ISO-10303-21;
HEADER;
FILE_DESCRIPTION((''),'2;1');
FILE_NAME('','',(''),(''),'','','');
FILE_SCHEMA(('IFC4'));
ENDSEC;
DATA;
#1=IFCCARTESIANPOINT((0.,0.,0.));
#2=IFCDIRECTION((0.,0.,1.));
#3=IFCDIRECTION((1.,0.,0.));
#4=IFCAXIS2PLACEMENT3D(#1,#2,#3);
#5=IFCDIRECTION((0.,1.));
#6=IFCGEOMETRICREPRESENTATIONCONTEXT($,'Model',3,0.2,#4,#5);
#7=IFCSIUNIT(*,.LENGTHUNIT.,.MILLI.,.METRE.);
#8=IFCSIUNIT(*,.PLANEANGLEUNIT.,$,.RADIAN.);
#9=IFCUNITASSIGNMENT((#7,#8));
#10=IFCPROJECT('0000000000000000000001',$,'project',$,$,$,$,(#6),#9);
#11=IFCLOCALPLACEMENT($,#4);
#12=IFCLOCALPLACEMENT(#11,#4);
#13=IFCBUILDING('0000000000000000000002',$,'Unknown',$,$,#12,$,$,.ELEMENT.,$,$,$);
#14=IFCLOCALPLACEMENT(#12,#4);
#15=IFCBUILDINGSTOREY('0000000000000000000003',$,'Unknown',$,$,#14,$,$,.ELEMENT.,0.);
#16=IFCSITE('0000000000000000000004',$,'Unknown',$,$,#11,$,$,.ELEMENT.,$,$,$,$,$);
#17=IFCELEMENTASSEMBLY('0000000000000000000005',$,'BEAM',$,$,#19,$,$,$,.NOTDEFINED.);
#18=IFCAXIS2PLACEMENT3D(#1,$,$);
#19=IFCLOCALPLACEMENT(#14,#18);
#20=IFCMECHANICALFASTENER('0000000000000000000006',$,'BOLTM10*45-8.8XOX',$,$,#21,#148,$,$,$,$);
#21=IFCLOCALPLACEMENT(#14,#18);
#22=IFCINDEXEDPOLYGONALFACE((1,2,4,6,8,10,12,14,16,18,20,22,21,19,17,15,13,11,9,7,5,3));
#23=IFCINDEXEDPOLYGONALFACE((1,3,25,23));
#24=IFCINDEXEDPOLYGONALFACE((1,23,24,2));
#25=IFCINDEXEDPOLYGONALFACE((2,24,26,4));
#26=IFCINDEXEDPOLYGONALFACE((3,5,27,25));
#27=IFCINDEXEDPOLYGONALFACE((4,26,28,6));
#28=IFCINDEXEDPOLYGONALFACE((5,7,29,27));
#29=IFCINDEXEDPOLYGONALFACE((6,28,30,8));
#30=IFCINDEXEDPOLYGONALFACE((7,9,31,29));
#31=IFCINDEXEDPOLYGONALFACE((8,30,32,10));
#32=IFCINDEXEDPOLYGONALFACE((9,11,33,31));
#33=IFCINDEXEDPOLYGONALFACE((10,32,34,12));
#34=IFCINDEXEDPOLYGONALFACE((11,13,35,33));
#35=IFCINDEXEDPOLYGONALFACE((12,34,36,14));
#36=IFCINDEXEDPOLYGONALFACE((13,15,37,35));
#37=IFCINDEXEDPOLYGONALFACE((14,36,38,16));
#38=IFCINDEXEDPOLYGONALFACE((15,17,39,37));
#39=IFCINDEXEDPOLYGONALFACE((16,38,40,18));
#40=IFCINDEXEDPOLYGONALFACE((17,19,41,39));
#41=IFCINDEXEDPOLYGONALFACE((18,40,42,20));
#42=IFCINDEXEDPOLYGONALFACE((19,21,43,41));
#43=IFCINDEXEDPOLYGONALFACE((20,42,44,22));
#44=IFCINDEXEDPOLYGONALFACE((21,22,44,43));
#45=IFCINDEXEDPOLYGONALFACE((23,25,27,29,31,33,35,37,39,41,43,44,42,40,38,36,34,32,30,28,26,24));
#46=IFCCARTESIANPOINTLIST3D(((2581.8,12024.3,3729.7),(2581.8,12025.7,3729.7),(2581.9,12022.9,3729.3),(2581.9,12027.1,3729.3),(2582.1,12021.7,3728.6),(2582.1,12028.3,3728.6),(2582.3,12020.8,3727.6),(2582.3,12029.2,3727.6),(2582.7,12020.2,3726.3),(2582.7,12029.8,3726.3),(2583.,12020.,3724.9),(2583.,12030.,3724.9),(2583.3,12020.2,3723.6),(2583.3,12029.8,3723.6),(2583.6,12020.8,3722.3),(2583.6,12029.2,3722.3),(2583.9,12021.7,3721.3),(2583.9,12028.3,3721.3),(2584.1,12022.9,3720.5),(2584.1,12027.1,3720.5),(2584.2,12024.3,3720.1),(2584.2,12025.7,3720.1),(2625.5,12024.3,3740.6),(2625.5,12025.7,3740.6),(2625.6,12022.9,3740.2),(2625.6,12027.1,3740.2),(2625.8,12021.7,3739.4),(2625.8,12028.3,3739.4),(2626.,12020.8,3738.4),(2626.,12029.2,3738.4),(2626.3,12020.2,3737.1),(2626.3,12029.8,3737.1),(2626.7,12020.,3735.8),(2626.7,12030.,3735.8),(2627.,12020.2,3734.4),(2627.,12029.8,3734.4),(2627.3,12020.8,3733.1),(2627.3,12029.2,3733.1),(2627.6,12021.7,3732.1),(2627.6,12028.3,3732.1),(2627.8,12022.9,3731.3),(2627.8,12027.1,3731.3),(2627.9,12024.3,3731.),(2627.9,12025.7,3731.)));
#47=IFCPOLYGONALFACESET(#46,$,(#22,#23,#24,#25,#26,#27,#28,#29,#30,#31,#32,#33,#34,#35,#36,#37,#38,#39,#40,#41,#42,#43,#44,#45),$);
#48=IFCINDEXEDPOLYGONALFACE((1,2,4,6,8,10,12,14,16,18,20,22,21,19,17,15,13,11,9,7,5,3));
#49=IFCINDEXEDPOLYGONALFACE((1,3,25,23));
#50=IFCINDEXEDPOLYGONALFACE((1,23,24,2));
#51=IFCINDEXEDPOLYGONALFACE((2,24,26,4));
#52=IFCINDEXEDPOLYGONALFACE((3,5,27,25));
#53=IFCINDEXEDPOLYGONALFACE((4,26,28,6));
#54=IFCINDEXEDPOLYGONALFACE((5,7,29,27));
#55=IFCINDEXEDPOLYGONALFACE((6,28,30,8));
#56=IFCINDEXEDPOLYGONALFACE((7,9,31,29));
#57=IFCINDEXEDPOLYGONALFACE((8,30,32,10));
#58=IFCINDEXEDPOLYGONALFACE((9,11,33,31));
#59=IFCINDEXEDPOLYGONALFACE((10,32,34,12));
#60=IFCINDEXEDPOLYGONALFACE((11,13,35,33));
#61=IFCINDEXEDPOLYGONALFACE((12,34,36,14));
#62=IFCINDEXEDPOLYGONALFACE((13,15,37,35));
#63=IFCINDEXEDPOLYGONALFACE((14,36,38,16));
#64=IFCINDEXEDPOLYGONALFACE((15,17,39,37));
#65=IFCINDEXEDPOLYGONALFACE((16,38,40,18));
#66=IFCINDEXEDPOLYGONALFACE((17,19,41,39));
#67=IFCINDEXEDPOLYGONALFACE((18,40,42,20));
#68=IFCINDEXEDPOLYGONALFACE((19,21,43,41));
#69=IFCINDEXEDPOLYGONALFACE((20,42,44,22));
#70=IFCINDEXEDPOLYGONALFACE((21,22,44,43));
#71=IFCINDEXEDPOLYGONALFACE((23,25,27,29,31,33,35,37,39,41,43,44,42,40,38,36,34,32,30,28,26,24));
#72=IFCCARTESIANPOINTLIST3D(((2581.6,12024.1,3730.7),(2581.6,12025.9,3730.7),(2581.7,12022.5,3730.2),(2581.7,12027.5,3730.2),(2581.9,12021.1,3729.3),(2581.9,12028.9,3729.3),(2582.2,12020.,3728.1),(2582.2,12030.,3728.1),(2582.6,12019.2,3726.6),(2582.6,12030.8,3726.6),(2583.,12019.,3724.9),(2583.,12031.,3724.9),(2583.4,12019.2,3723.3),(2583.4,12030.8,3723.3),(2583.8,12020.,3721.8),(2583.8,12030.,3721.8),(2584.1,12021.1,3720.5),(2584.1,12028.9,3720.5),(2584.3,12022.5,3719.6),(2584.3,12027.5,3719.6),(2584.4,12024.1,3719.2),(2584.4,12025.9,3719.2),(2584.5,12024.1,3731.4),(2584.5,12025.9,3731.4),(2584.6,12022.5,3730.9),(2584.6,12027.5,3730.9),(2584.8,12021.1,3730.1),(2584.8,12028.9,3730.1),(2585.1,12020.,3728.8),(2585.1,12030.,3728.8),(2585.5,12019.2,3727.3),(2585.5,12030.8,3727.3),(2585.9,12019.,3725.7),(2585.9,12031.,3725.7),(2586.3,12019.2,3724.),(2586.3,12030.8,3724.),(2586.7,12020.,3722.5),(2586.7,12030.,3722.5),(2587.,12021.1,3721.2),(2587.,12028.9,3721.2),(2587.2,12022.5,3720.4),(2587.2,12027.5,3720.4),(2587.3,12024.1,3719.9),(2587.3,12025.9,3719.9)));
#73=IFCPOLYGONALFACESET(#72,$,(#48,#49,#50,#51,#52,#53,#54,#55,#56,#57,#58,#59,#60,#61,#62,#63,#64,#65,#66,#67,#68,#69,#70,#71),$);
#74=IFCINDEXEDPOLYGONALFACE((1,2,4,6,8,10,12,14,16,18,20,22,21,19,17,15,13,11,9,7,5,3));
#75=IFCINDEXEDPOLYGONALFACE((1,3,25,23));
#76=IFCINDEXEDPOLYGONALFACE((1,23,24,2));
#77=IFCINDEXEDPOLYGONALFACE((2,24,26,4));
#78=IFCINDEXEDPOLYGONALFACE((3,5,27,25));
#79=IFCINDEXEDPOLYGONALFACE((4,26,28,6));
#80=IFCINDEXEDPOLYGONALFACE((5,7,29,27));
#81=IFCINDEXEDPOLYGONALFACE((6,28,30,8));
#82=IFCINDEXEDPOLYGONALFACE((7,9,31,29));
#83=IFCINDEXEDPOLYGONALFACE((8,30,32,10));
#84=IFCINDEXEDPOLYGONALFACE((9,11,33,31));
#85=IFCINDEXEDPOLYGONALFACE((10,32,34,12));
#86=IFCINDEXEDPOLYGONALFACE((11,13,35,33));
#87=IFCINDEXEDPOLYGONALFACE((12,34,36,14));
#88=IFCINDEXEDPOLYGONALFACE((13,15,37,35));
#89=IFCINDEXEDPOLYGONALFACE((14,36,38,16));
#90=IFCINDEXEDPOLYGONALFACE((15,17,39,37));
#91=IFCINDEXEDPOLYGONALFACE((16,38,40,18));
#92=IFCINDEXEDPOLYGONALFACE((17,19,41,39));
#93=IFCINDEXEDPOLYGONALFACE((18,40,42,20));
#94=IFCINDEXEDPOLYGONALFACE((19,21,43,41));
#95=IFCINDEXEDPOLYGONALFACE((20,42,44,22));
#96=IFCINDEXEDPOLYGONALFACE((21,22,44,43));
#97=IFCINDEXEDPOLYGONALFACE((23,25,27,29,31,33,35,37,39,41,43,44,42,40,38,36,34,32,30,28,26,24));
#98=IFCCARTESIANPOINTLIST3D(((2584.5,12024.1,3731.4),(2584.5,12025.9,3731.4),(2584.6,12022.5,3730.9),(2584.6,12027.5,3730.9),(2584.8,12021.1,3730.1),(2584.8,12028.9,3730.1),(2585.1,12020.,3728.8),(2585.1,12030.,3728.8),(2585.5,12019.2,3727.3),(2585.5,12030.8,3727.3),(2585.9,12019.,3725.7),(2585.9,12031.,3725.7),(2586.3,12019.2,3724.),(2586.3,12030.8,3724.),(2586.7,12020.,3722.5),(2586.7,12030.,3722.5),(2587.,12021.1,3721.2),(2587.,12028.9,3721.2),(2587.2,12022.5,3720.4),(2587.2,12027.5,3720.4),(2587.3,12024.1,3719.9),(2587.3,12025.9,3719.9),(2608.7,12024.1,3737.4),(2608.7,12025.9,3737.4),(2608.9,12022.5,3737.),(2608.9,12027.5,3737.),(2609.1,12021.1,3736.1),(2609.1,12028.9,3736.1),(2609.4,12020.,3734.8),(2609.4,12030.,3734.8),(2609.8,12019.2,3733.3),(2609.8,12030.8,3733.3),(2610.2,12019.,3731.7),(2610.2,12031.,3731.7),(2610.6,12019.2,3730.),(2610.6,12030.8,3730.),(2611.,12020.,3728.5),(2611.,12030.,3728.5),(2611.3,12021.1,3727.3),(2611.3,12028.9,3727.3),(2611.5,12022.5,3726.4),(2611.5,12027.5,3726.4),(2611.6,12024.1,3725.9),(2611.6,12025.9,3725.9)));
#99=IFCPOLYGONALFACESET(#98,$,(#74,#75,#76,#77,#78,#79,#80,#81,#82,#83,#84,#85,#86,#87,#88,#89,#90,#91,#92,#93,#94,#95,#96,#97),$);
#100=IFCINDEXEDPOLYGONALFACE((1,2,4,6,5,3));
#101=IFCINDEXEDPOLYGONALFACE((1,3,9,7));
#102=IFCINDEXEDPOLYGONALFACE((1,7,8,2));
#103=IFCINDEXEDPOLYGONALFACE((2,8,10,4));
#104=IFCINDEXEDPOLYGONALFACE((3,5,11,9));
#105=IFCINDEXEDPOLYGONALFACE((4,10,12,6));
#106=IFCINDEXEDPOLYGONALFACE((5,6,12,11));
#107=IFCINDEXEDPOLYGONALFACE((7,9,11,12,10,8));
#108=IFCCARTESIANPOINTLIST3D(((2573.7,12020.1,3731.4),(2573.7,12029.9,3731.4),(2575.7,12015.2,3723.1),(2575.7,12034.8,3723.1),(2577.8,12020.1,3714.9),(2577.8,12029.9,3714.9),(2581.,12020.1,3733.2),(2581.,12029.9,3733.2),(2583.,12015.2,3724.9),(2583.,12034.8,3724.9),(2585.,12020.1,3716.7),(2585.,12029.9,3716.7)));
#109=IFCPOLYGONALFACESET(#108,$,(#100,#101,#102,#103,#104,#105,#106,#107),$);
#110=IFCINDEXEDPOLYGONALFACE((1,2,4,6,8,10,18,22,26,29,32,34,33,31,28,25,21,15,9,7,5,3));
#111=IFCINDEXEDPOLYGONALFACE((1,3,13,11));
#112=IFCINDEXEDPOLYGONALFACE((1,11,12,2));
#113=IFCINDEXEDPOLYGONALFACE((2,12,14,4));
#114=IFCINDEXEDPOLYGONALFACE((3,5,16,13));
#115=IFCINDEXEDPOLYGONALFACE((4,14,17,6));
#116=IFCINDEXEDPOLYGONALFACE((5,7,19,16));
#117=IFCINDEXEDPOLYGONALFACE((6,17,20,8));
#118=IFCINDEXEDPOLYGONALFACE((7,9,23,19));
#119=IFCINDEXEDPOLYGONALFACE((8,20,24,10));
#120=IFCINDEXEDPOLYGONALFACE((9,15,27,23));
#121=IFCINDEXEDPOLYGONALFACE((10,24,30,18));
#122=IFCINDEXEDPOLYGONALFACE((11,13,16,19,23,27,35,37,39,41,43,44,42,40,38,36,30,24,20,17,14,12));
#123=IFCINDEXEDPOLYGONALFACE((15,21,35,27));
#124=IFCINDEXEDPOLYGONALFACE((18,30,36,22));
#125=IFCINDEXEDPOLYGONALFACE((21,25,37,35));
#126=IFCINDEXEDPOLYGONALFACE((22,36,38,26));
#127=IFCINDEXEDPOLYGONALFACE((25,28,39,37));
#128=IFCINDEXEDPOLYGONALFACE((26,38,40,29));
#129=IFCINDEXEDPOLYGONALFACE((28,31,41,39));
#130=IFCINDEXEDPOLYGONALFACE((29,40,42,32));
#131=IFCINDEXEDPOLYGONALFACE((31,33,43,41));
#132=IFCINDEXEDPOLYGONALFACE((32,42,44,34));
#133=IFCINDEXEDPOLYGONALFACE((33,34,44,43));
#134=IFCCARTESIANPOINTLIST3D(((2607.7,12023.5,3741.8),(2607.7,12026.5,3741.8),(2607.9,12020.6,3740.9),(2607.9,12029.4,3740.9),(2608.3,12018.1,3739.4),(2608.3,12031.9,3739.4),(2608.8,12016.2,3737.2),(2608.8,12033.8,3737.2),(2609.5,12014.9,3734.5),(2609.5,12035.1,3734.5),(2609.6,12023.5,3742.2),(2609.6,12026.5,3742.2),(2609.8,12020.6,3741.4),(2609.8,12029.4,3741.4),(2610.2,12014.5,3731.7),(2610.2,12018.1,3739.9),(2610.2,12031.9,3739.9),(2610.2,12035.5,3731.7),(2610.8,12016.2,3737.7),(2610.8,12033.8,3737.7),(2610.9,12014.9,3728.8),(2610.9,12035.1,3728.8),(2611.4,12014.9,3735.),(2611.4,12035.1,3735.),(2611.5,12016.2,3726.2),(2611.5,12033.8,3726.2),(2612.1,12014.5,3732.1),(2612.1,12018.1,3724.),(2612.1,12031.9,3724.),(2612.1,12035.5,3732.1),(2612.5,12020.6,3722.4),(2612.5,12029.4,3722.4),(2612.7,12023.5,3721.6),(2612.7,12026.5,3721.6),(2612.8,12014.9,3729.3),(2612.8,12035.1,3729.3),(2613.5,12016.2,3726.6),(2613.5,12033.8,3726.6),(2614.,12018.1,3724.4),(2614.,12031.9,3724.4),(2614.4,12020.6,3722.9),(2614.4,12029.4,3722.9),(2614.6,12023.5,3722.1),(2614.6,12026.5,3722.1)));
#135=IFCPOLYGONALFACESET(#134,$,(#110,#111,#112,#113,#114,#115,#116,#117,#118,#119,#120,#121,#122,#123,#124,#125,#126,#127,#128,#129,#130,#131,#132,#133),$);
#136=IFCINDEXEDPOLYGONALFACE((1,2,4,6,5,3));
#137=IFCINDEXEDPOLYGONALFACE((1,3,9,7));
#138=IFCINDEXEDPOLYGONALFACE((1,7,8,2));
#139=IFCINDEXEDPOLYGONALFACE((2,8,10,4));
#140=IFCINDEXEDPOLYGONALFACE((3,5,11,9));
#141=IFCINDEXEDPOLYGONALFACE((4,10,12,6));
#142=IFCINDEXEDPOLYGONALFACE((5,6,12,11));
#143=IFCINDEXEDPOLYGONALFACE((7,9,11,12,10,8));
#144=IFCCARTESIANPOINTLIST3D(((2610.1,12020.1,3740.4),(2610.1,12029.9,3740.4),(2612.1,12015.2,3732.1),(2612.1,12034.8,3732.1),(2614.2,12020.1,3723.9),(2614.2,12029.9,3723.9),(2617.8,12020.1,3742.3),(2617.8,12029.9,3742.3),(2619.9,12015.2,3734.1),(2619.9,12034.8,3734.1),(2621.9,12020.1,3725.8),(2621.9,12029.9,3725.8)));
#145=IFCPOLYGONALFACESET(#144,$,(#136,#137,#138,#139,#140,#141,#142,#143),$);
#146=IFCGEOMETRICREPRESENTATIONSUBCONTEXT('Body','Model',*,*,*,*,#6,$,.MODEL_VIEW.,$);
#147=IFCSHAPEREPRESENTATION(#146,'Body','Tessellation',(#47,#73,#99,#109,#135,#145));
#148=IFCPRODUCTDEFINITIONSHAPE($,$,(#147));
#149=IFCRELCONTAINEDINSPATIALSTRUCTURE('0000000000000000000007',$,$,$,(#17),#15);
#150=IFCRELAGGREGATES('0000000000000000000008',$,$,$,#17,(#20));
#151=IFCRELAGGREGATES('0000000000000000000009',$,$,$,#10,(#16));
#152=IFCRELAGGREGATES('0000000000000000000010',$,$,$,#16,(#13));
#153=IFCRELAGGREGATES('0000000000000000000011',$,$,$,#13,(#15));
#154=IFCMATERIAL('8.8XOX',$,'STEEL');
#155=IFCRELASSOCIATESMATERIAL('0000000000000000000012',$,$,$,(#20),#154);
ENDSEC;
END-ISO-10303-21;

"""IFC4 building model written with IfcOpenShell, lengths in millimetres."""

from ifc_helpers import new_model, si_unit, direction, frame, origin_with_axes, place, context, subcontext, project, spatial, line, arc, indexed_curve, outline, extrude, source, transform, mapped, material, element, aggregate, save


model = new_model("IFC4")

# Units and contexts
model_context = context("Model", 3, precision=0.2, world=origin_with_axes(), true_north=direction((0.0, 1.0)))
body_context = subcontext(model_context, "Body", "Model", "MODEL_VIEW")
ifc_project = project(units=[si_unit("LENGTHUNIT", "METRE", prefix="MILLI"), si_unit("PLANEANGLEUNIT", "RADIAN")], contexts=[model_context])

# Site, building, storey
site_placement = place(None, origin_with_axes())
site = spatial("IfcSite", under=ifc_project, at=site_placement, Name="Unknown", CompositionType="ELEMENT")
building_placement = place(site_placement, origin_with_axes())
building = spatial("IfcBuilding", under=site, at=building_placement, Name="Unknown", CompositionType="ELEMENT")
storey_placement = place(building_placement, origin_with_axes())
storey = spatial("IfcBuildingStorey", under=building, at=storey_placement, Name="Unknown", CompositionType="ELEMENT", Elevation=0.0)

# Shared definitions
ifc_material_1 = material(Name="8.8XOX", Category="STEEL")

# Element assembly, mechanical fastener
shared_shape_1 = source(origin_with_axes(), body_context, "Body", "SweptSolid", [
    extrude(outline(indexed_curve([(5.0, 0.0), (0.0, 5.0), (-5.0, 0.0), (0.0, -5.0)], segments=[arc(1, 2, 3), arc(3, 4, 1)])), frame((0.0, 0.0, 3.8), z_axis=(0.0, 0.0, -1.0), x_axis=(0.0, 1.0, 0.0)), (0.0, 0.0, 1.0), 45.0),
    extrude(outline(indexed_curve([(6.0, 0.0), (0.0, 6.0), (-6.0, 0.0), (0.0, -6.0)], segments=[arc(1, 2, 3), arc(3, 4, 1)])), frame((0.0, 0.0, 3.8), z_axis=(0.0, 0.0, -1.0), x_axis=(0.0, 1.0, 0.0)), (0.0, 0.0, 1.0), 3.0),
    extrude(outline(indexed_curve([(6.0, 0.0), (0.0, 6.0), (-6.0, 0.0), (0.0, -6.0)], segments=[arc(1, 2, 3), arc(3, 4, 1)])), frame((0.0, 0.0, 0.8), z_axis=(0.0, 0.0, -1.0), x_axis=(0.0, 1.0, 0.0)), (0.0, 0.0, 1.0), 25.0),
    extrude(outline(indexed_curve([(9.8, 0.0), (4.9, 8.5), (-4.9, 8.5), (-9.8, 0.0), (-4.9, -8.5), (4.9, -8.5)], segments=[line(1, 2, 3, 4, 5, 6, 1)])), frame((0.0, 0.0, 11.2), z_axis=(0.0, 0.0, -1.0), x_axis=(0.0, 1.0, 0.0)), (0.0, 0.0, 1.0), 7.5),
    extrude(outline(indexed_curve([(10.5, 0.0), (0.0, 10.5), (-10.5, 0.0), (0.0, -10.5)], segments=[arc(1, 2, 3), arc(3, 4, 1)])), frame((0.0, 0.0, -24.2), z_axis=(0.0, 0.0, -1.0), x_axis=(0.0, 1.0, 0.0)), (0.0, 0.0, 1.0), 2.0),
    extrude(outline(indexed_curve([(9.8, 0.0), (4.9, 8.5), (-4.9, 8.5), (-9.8, 0.0), (-4.9, -8.5), (4.9, -8.5)], segments=[line(1, 2, 3, 4, 5, 6, 1)])), frame((0.0, 0.0, -26.2), z_axis=(0.0, 0.0, -1.0), x_axis=(0.0, 1.0, 0.0)), (0.0, 0.0, 1.0), 8.0),
])
assembly_1_placement = place(storey_placement, frame((2596.8, 12000.0, 3733.5), z_axis=(0.970613, 0.0, 0.240648), x_axis=(0.0, 1.0, 0.0)))
assembly_1 = element("IfcElementAssembly", 1, at=assembly_1_placement, inside=storey, Name="BEAM", PredefinedType="NOTDEFINED")
mechanical_fastener_1_placement = place(assembly_1_placement, frame((25.0, -5.0, -11.8), z_axis=(0.0, 0.0, -1.0), x_axis=(0.0, 1.0, 0.0)))
mechanical_fastener_1 = element("IfcMechanicalFastener", 2, at=mechanical_fastener_1_placement, material=ifc_material_1, Name="BOLTM10*45-8.8XOX", context=body_context, shape_type="MappedRepresentation", body=[
    mapped(shared_shape_1, transform((0.0, 0.0, 0.0))),
])
aggregate(assembly_1, [mechanical_fastener_1])

save(model, "model.ifc")
